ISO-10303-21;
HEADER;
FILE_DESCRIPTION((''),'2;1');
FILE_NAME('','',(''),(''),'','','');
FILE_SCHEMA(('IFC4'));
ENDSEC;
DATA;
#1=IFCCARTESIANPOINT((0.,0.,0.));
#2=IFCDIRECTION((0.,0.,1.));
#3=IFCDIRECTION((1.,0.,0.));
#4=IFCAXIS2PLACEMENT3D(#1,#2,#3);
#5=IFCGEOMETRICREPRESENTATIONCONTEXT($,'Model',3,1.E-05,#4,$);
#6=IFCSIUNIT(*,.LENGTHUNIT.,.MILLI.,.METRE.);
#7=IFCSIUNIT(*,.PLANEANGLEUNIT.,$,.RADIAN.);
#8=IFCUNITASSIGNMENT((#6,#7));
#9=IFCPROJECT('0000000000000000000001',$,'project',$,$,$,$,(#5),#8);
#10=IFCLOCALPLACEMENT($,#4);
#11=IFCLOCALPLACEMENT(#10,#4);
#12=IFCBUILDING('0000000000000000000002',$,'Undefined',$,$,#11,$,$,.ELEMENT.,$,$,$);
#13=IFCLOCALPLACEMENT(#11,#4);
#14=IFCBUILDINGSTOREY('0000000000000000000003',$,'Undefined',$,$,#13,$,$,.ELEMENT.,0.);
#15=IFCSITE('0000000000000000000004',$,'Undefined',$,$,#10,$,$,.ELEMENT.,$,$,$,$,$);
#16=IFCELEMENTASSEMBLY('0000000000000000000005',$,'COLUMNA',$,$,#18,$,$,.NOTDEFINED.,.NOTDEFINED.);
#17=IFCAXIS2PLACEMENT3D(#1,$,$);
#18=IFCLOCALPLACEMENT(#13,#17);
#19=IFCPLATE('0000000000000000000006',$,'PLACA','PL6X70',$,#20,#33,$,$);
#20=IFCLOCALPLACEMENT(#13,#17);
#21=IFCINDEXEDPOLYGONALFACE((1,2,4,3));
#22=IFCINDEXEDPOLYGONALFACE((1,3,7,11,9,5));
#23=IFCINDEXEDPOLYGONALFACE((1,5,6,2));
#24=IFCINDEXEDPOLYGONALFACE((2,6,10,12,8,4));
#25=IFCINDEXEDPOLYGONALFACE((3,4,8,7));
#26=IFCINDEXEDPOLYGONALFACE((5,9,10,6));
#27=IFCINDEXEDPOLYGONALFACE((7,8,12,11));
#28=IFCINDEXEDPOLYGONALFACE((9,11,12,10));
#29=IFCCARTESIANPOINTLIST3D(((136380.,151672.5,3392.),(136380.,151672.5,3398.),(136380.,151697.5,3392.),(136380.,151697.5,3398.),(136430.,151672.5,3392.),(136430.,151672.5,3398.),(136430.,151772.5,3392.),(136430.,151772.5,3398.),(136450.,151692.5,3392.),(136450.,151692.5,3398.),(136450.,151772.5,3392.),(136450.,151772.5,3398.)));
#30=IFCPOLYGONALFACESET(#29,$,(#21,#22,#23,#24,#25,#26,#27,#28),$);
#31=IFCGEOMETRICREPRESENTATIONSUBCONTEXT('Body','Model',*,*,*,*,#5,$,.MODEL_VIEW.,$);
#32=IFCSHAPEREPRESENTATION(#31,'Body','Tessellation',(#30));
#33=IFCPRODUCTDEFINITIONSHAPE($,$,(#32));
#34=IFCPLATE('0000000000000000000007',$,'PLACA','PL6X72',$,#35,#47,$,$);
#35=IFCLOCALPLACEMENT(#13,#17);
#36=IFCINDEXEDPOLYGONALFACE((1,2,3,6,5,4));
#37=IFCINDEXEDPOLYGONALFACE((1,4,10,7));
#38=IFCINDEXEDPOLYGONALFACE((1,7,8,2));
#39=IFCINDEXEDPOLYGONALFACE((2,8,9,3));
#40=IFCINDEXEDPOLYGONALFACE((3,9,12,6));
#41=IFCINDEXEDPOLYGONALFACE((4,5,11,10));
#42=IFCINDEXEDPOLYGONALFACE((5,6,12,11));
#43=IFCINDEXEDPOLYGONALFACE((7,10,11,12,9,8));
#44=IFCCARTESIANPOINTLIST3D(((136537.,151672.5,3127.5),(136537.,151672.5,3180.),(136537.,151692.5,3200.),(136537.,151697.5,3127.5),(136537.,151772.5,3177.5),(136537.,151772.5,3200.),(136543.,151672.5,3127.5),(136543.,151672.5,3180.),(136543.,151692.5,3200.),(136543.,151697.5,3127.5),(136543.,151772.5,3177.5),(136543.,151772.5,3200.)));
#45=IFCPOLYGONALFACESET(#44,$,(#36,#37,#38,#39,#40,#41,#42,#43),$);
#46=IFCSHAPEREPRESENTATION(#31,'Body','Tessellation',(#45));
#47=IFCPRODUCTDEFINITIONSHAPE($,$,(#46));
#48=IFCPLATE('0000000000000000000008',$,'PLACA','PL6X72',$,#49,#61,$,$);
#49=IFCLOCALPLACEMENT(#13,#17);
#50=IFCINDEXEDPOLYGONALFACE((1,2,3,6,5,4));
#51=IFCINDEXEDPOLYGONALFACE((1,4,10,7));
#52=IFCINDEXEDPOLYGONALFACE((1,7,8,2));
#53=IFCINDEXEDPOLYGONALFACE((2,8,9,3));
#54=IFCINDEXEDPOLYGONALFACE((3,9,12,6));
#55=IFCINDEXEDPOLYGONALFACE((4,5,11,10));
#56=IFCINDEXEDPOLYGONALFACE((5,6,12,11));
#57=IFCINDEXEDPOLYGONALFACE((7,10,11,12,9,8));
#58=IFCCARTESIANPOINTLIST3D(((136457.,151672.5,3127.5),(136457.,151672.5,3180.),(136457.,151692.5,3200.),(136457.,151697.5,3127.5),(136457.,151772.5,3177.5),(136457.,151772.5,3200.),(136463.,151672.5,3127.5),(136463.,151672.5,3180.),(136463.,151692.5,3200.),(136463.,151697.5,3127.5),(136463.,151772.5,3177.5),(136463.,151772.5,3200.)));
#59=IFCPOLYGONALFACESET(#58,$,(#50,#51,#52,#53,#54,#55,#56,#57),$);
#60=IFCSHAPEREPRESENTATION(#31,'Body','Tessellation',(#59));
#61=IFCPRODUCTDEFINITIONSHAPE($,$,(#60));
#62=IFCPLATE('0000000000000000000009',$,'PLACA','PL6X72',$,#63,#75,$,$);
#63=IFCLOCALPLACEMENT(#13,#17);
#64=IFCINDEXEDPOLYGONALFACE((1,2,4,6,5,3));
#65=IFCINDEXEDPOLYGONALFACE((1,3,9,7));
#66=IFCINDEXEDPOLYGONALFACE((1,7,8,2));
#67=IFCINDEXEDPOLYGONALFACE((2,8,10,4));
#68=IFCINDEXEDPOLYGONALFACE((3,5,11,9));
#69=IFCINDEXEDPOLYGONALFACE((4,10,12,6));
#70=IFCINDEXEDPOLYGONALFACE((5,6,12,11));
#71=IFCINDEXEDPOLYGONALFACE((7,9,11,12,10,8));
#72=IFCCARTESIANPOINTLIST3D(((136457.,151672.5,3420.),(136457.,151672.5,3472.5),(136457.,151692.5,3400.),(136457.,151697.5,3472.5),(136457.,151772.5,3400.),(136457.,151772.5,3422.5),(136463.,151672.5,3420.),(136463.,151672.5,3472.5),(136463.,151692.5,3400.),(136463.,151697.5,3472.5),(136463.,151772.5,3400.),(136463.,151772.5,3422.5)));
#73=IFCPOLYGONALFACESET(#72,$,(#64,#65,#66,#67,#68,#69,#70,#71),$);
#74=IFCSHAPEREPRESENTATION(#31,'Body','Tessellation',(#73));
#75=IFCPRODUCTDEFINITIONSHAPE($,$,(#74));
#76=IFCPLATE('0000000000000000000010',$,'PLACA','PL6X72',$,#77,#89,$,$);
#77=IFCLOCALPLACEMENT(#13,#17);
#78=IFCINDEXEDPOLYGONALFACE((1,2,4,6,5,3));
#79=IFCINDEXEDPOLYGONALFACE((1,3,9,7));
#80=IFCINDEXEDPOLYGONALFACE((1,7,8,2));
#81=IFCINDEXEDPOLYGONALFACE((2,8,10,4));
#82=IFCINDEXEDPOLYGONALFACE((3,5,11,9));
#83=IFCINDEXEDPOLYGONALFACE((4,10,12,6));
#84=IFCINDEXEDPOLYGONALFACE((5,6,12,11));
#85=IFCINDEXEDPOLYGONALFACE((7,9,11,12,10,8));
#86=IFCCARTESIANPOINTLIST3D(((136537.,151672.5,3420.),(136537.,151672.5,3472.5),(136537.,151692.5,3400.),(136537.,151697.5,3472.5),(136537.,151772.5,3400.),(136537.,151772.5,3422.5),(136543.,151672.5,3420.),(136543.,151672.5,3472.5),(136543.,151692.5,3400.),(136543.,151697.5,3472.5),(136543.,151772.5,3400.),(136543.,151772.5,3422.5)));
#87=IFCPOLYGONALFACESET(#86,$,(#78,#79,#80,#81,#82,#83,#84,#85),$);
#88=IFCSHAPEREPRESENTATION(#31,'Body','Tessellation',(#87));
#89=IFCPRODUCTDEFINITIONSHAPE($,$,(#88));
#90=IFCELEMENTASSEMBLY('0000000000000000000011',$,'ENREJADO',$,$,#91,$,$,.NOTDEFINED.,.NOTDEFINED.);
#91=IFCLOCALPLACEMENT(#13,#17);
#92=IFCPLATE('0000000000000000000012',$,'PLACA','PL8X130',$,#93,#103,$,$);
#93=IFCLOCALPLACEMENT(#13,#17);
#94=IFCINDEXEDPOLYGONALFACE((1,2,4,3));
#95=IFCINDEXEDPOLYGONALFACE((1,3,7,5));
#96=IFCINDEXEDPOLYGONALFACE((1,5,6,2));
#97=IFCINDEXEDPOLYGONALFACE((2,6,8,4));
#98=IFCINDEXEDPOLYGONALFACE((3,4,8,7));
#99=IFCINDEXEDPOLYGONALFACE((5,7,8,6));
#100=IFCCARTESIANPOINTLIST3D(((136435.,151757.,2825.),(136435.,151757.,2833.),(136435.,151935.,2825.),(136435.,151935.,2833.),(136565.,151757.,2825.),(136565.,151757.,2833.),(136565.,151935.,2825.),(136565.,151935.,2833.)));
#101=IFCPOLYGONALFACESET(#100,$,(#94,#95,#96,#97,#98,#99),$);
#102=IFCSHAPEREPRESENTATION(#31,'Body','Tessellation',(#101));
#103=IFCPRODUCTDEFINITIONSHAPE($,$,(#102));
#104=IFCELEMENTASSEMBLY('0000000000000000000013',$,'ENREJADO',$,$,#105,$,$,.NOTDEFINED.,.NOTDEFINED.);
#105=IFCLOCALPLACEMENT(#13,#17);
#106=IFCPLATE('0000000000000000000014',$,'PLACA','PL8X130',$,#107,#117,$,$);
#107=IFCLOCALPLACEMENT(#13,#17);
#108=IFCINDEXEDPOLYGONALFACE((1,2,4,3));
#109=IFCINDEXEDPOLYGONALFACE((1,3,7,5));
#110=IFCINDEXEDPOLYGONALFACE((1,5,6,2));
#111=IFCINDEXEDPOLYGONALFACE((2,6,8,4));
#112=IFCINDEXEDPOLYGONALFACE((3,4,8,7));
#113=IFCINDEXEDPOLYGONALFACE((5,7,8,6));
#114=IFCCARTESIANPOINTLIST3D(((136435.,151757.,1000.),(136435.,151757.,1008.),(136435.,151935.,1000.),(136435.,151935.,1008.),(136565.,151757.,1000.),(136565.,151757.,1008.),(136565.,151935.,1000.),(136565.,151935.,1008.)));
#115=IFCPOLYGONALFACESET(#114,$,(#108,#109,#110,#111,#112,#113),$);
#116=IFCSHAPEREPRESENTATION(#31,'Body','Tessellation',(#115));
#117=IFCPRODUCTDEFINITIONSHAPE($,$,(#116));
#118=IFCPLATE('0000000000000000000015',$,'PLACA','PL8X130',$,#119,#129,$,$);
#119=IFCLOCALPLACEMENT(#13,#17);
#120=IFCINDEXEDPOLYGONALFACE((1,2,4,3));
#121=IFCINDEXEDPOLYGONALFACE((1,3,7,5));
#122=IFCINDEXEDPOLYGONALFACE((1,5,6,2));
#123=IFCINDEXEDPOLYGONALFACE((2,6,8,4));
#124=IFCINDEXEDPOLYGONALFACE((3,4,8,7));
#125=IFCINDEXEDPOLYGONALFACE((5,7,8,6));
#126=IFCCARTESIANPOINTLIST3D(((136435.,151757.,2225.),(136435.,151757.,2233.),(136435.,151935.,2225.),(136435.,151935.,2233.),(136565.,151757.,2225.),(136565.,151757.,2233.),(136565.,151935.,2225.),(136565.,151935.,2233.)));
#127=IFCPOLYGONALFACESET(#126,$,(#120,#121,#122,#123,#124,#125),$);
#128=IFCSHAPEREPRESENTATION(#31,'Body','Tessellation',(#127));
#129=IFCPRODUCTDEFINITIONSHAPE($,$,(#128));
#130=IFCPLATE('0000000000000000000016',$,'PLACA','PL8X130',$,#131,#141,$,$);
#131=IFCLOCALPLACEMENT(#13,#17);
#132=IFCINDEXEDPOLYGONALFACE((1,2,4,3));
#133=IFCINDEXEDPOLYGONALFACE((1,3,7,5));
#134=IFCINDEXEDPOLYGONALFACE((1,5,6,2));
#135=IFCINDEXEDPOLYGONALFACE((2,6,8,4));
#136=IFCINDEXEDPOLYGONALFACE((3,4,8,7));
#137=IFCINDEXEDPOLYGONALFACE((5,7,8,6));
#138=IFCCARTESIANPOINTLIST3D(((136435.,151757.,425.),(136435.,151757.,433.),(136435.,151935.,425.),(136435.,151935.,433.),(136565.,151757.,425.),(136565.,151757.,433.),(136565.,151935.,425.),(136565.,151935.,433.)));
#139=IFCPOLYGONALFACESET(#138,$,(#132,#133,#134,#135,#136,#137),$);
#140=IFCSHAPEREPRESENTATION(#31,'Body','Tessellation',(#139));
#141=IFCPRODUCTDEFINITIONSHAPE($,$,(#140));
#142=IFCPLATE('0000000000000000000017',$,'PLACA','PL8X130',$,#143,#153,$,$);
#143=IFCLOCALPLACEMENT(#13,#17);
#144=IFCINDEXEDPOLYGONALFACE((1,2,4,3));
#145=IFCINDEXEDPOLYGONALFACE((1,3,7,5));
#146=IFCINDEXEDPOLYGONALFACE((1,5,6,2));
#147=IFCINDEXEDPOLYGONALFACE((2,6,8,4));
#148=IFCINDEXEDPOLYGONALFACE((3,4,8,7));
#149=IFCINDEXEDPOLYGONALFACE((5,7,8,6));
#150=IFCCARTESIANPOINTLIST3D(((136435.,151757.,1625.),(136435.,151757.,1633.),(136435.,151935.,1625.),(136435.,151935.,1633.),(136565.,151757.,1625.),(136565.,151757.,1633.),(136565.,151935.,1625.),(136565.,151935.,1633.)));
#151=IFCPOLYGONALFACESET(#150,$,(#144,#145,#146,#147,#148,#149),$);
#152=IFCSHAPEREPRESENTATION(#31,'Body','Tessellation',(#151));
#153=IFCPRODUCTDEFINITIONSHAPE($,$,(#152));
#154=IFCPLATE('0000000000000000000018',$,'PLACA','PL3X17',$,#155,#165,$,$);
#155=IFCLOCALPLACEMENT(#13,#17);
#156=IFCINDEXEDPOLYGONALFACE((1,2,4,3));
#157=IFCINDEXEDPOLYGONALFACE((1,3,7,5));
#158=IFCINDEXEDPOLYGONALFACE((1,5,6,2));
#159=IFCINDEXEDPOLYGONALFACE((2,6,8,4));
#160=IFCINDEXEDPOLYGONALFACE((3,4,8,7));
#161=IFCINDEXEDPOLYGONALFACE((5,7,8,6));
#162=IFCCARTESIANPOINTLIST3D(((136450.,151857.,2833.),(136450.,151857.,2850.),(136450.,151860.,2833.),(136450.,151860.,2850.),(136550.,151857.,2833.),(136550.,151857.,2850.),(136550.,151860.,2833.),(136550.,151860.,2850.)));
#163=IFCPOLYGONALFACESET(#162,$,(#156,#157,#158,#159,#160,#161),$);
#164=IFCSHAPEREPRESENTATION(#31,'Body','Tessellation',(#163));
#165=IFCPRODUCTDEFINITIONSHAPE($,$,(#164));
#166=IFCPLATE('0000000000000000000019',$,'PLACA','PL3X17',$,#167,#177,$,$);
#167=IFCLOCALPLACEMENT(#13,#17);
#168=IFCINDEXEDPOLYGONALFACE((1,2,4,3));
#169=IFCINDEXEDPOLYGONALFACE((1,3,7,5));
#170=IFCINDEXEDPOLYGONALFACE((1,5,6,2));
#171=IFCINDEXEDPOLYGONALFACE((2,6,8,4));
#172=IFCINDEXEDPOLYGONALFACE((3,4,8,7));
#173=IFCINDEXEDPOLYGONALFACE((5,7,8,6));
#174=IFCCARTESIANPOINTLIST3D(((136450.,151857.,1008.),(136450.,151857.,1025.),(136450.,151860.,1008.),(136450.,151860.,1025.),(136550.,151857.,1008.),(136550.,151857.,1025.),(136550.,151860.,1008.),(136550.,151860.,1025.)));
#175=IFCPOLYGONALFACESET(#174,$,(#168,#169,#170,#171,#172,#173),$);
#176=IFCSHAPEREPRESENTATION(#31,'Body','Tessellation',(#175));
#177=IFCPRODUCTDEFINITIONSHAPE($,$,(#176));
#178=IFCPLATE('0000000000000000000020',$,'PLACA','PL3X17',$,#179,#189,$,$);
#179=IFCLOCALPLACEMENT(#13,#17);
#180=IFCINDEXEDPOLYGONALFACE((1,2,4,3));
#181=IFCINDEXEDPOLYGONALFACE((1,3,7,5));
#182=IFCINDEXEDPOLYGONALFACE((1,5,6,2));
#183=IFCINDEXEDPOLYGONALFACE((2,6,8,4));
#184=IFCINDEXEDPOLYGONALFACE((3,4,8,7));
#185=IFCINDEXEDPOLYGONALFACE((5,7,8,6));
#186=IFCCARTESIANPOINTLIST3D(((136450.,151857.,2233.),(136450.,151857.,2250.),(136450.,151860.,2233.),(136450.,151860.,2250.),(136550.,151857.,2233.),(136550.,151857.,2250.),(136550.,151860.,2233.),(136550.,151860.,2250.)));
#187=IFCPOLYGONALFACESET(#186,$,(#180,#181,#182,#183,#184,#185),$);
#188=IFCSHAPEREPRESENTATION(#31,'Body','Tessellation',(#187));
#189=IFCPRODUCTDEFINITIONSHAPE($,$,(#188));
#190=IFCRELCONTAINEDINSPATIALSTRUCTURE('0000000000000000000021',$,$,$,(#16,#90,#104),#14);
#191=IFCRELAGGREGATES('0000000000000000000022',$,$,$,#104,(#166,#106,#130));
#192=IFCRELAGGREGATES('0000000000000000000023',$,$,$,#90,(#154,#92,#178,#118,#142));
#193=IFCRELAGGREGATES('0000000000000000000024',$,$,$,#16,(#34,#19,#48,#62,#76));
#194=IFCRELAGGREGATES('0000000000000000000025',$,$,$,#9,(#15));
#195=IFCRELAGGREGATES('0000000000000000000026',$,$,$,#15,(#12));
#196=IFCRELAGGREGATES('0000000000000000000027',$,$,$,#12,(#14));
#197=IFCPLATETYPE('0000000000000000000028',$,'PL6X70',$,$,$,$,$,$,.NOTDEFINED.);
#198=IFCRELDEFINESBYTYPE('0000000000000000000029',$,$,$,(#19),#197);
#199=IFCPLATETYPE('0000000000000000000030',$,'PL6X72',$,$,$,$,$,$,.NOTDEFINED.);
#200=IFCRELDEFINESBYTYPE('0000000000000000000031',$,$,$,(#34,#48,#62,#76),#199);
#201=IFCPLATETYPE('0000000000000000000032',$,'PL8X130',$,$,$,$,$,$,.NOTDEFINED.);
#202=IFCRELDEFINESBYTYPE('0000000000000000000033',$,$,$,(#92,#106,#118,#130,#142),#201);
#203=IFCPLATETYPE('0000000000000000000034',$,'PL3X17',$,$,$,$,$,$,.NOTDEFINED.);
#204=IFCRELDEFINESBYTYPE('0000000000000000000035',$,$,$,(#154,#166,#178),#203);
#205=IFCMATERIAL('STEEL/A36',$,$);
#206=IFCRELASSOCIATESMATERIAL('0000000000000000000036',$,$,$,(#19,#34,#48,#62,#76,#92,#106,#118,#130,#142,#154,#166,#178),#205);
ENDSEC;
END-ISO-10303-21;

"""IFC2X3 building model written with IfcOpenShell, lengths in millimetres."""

from ifc_helpers import new_model, si_unit, frame, origin_with_axes, place, context, subcontext, project, spatial, polyline, outline, extrude, material, type_object, element, aggregate, save


model = new_model("IFC2X3")

# Units and contexts
model_context = context("Model", 3, precision=1e-05, world=origin_with_axes())
body_context = subcontext(model_context, "Body", "Model", "MODEL_VIEW")
ifc_project = project(units=[si_unit("LENGTHUNIT", "METRE", prefix="MILLI"), si_unit("PLANEANGLEUNIT", "RADIAN")], contexts=[model_context])

# Site, building, storey
site_placement = place(None, origin_with_axes())
site = spatial("IfcSite", under=ifc_project, at=site_placement, Name="Undefined", CompositionType="ELEMENT")
building_placement = place(site_placement, origin_with_axes())
building = spatial("IfcBuilding", under=site, at=building_placement, Name="Undefined", CompositionType="ELEMENT")
storey_placement = place(building_placement, origin_with_axes())
storey = spatial("IfcBuildingStorey", under=building, at=storey_placement, Name="Undefined", CompositionType="ELEMENT", Elevation=0.0)

# Element assembly
assembly_1_placement = place(storey_placement, origin_with_axes())
assembly_1 = element("IfcElementAssembly", 1, at=assembly_1_placement, inside=storey, Name="COLUMNA", AssemblyPlace="NOTDEFINED", PredefinedType="NOTDEFINED")
ifc_material_1 = material(Name="STEEL/A36")

# Plates
plate_type_1 = type_object("IfcPlateType", Name="PL6X70", PredefinedType="NOTDEFINED")
plate_1_placement = place(assembly_1_placement, frame((136380.0, 151672.5, 3395.0), z_axis=(0.0, 0.0, -1.0), x_axis=(0.0, 1.0, 0.0)))
plate_1 = element("IfcPlate", 2, at=plate_1_placement, type_object=plate_type_1, material=ifc_material_1, Name="PLACA", Description="PL6X70", context=body_context, shape_type="SweptSolid", body=[
    extrude(outline(polyline([(0.0, 0.0), (25.0, 0.0), (100.0, 50.0), (100.0, 70.0), (20.0, 70.0), (0.0, 50.0), (0.0, 0.0)])), frame((0.0, 0.0, -3.0), z_axis=(0.0, 0.0, 1.0), x_axis=(1.0, 0.0, 0.0)), (0.0, 0.0, 1.0), 6.0),
])
plate_type_2 = type_object("IfcPlateType", Name="PL6X72", PredefinedType="NOTDEFINED")
plate_2_placement = place(assembly_1_placement, frame((136540.0, 151672.5, 3127.5), z_axis=(1.0, 0.0, 0.0), x_axis=(0.0, 1.0, 0.0)))
plate_2 = element("IfcPlate", 3, at=plate_2_placement, type_object=plate_type_2, material=ifc_material_1, Name="PLACA", Description="PL6X72", context=body_context, shape_type="SweptSolid", body=[
    extrude(outline(polyline([(0.0, 0.0), (25.0, 0.0), (100.0, 50.0), (100.0, 72.5), (20.0, 72.5), (0.0, 52.5), (0.0, 0.0)])), frame((0.0, 0.0, -3.0), z_axis=(0.0, 0.0, 1.0), x_axis=(1.0, 0.0, 0.0)), (0.0, 0.0, 1.0), 6.0),
])
plate_3_placement = place(assembly_1_placement, frame((136460.0, 151672.5, 3127.5), z_axis=(1.0, 0.0, 0.0), x_axis=(0.0, 1.0, 0.0)))
plate_3 = element("IfcPlate", 4, at=plate_3_placement, type_object=plate_type_2, material=ifc_material_1, Name="PLACA", Description="PL6X72", context=body_context, shape_type="SweptSolid", body=[
    extrude(outline(polyline([(0.0, 0.0), (25.0, 0.0), (100.0, 50.0), (100.0, 72.5), (20.0, 72.5), (0.0, 52.5), (0.0, 0.0)])), frame((0.0, 0.0, -3.0), z_axis=(0.0, 0.0, 1.0), x_axis=(1.0, 0.0, 0.0)), (0.0, 0.0, 1.0), 6.0),
])
plate_4_placement = place(assembly_1_placement, frame((136460.0, 151672.5, 3472.5), z_axis=(-1.0, 0.0, 0.0), x_axis=(0.0, 1.0, 0.0)))
plate_4 = element("IfcPlate", 5, at=plate_4_placement, type_object=plate_type_2, material=ifc_material_1, Name="PLACA", Description="PL6X72", context=body_context, shape_type="SweptSolid", body=[
    extrude(outline(polyline([(0.0, 0.0), (25.0, 0.0), (100.0, 50.0), (100.0, 72.5), (20.0, 72.5), (0.0, 52.5), (0.0, 0.0)])), frame((0.0, 0.0, -3.0), z_axis=(0.0, 0.0, 1.0), x_axis=(1.0, 0.0, 0.0)), (0.0, 0.0, 1.0), 6.0),
])
plate_5_placement = place(assembly_1_placement, frame((136540.0, 151672.5, 3472.5), z_axis=(-1.0, 0.0, 0.0), x_axis=(0.0, 1.0, 0.0)))
plate_5 = element("IfcPlate", 6, at=plate_5_placement, type_object=plate_type_2, material=ifc_material_1, Name="PLACA", Description="PL6X72", context=body_context, shape_type="SweptSolid", body=[
    extrude(outline(polyline([(0.0, 0.0), (25.0, 0.0), (100.0, 50.0), (100.0, 72.5), (20.0, 72.5), (0.0, 52.5), (0.0, 0.0)])), frame((0.0, 0.0, -3.0), z_axis=(0.0, 0.0, 1.0), x_axis=(1.0, 0.0, 0.0)), (0.0, 0.0, 1.0), 6.0),
])

# Element assemblies, plates
assembly_2_placement = place(storey_placement, origin_with_axes())
assembly_2 = element("IfcElementAssembly", 7, at=assembly_2_placement, inside=storey, Name="ENREJADO", AssemblyPlace="NOTDEFINED", PredefinedType="NOTDEFINED")
plate_type_3 = type_object("IfcPlateType", Name="PL8X130", PredefinedType="NOTDEFINED")
plate_6_placement = place(assembly_2_placement, frame((136500.0, 151935.0, 2829.0), z_axis=(0.0, 0.0, -1.0), x_axis=(0.0, -1.0, 0.0)))
plate_6 = element("IfcPlate", 8, at=plate_6_placement, type_object=plate_type_3, material=ifc_material_1, Name="PLACA", Description="PL8X130", context=body_context, shape_type="SweptSolid", body=[
    extrude(outline(polyline([(0.0, -65.0), (0.0, 65.0), (178.0, 65.0), (178.0, -65.0), (0.0, -65.0)])), frame((0.0, 0.0, -4.0), z_axis=(0.0, 0.0, 1.0), x_axis=(1.0, 0.0, 0.0)), (0.0, 0.0, 1.0), 8.0),
])
assembly_3_placement = place(storey_placement, origin_with_axes())
assembly_3 = element("IfcElementAssembly", 9, at=assembly_3_placement, inside=storey, Name="ENREJADO", AssemblyPlace="NOTDEFINED", PredefinedType="NOTDEFINED")
plate_7_placement = place(assembly_3_placement, frame((136500.0, 151935.0, 1004.0), z_axis=(0.0, 0.0, -1.0), x_axis=(0.0, -1.0, 0.0)))
plate_7 = element("IfcPlate", 10, at=plate_7_placement, type_object=plate_type_3, material=ifc_material_1, Name="PLACA", Description="PL8X130", context=body_context, shape_type="SweptSolid", body=[
    extrude(outline(polyline([(0.0, -65.0), (0.0, 65.0), (178.0, 65.0), (178.0, -65.0), (0.0, -65.0)])), frame((0.0, 0.0, -4.0), z_axis=(0.0, 0.0, 1.0), x_axis=(1.0, 0.0, 0.0)), (0.0, 0.0, 1.0), 8.0),
])

# Plates
plate_8_placement = place(assembly_2_placement, frame((136500.0, 151935.0, 2229.0), z_axis=(0.0, 0.0, -1.0), x_axis=(0.0, -1.0, 0.0)))
plate_8 = element("IfcPlate", 11, at=plate_8_placement, type_object=plate_type_3, material=ifc_material_1, Name="PLACA", Description="PL8X130", context=body_context, shape_type="SweptSolid", body=[
    extrude(outline(polyline([(0.0, -65.0), (0.0, 65.0), (178.0, 65.0), (178.0, -65.0), (0.0, -65.0)])), frame((0.0, 0.0, -4.0), z_axis=(0.0, 0.0, 1.0), x_axis=(1.0, 0.0, 0.0)), (0.0, 0.0, 1.0), 8.0),
])
plate_9_placement = place(assembly_3_placement, frame((136500.0, 151935.0, 429.0), z_axis=(0.0, 0.0, -1.0), x_axis=(0.0, -1.0, 0.0)))
plate_9 = element("IfcPlate", 12, at=plate_9_placement, type_object=plate_type_3, material=ifc_material_1, Name="PLACA", Description="PL8X130", context=body_context, shape_type="SweptSolid", body=[
    extrude(outline(polyline([(0.0, -65.0), (0.0, 65.0), (178.0, 65.0), (178.0, -65.0), (0.0, -65.0)])), frame((0.0, 0.0, -4.0), z_axis=(0.0, 0.0, 1.0), x_axis=(1.0, 0.0, 0.0)), (0.0, 0.0, 1.0), 8.0),
])
plate_10_placement = place(assembly_2_placement, frame((136500.0, 151935.0, 1629.0), z_axis=(0.0, 0.0, -1.0), x_axis=(0.0, -1.0, 0.0)))
plate_10 = element("IfcPlate", 13, at=plate_10_placement, type_object=plate_type_3, material=ifc_material_1, Name="PLACA", Description="PL8X130", context=body_context, shape_type="SweptSolid", body=[
    extrude(outline(polyline([(0.0, -65.0), (0.0, 65.0), (178.0, 65.0), (178.0, -65.0), (0.0, -65.0)])), frame((0.0, 0.0, -4.0), z_axis=(0.0, 0.0, 1.0), x_axis=(1.0, 0.0, 0.0)), (0.0, 0.0, 1.0), 8.0),
])
plate_type_4 = type_object("IfcPlateType", Name="PL3X17", PredefinedType="NOTDEFINED")
plate_11_placement = place(assembly_2_placement, frame((136450.0, 151858.5, 2850.0), z_axis=(0.0, -1.0, 0.0), x_axis=(0.0, 0.0, -1.0)))
plate_11 = element("IfcPlate", 14, at=plate_11_placement, type_object=plate_type_4, material=ifc_material_1, Name="PLACA", Description="PL3X17", context=body_context, shape_type="SweptSolid", body=[
    extrude(outline(polyline([(0.0, 0.0), (17.0, 0.0), (17.0, 100.0), (0.0, 100.0), (0.0, 0.0)])), frame((0.0, 0.0, -1.5), z_axis=(0.0, 0.0, 1.0), x_axis=(1.0, 0.0, 0.0)), (0.0, 0.0, 1.0), 3.0),
])
plate_12_placement = place(assembly_3_placement, frame((136450.0, 151858.5, 1025.0), z_axis=(0.0, -1.0, 0.0), x_axis=(0.0, 0.0, -1.0)))
plate_12 = element("IfcPlate", 15, at=plate_12_placement, type_object=plate_type_4, material=ifc_material_1, Name="PLACA", Description="PL3X17", context=body_context, shape_type="SweptSolid", body=[
    extrude(outline(polyline([(0.0, 0.0), (17.0, 0.0), (17.0, 100.0), (0.0, 100.0), (0.0, 0.0)])), frame((0.0, 0.0, -1.5), z_axis=(0.0, 0.0, 1.0), x_axis=(1.0, 0.0, 0.0)), (0.0, 0.0, 1.0), 3.0),
])
plate_13_placement = place(assembly_2_placement, frame((136450.0, 151858.5, 2250.0), z_axis=(0.0, -1.0, 0.0), x_axis=(0.0, 0.0, -1.0)))
plate_13 = element("IfcPlate", 16, at=plate_13_placement, type_object=plate_type_4, material=ifc_material_1, Name="PLACA", Description="PL3X17", context=body_context, shape_type="SweptSolid", body=[
    extrude(outline(polyline([(0.0, 0.0), (17.0, 0.0), (17.0, 100.0), (0.0, 100.0), (0.0, 0.0)])), frame((0.0, 0.0, -1.5), z_axis=(0.0, 0.0, 1.0), x_axis=(1.0, 0.0, 0.0)), (0.0, 0.0, 1.0), 3.0),
])
aggregate(assembly_3, [plate_12, plate_7, plate_9])
aggregate(assembly_2, [plate_11, plate_6, plate_13, plate_8, plate_10])

aggregate(assembly_1, [plate_2, plate_1, plate_3, plate_4, plate_5])

save(model, "model.ifc")
